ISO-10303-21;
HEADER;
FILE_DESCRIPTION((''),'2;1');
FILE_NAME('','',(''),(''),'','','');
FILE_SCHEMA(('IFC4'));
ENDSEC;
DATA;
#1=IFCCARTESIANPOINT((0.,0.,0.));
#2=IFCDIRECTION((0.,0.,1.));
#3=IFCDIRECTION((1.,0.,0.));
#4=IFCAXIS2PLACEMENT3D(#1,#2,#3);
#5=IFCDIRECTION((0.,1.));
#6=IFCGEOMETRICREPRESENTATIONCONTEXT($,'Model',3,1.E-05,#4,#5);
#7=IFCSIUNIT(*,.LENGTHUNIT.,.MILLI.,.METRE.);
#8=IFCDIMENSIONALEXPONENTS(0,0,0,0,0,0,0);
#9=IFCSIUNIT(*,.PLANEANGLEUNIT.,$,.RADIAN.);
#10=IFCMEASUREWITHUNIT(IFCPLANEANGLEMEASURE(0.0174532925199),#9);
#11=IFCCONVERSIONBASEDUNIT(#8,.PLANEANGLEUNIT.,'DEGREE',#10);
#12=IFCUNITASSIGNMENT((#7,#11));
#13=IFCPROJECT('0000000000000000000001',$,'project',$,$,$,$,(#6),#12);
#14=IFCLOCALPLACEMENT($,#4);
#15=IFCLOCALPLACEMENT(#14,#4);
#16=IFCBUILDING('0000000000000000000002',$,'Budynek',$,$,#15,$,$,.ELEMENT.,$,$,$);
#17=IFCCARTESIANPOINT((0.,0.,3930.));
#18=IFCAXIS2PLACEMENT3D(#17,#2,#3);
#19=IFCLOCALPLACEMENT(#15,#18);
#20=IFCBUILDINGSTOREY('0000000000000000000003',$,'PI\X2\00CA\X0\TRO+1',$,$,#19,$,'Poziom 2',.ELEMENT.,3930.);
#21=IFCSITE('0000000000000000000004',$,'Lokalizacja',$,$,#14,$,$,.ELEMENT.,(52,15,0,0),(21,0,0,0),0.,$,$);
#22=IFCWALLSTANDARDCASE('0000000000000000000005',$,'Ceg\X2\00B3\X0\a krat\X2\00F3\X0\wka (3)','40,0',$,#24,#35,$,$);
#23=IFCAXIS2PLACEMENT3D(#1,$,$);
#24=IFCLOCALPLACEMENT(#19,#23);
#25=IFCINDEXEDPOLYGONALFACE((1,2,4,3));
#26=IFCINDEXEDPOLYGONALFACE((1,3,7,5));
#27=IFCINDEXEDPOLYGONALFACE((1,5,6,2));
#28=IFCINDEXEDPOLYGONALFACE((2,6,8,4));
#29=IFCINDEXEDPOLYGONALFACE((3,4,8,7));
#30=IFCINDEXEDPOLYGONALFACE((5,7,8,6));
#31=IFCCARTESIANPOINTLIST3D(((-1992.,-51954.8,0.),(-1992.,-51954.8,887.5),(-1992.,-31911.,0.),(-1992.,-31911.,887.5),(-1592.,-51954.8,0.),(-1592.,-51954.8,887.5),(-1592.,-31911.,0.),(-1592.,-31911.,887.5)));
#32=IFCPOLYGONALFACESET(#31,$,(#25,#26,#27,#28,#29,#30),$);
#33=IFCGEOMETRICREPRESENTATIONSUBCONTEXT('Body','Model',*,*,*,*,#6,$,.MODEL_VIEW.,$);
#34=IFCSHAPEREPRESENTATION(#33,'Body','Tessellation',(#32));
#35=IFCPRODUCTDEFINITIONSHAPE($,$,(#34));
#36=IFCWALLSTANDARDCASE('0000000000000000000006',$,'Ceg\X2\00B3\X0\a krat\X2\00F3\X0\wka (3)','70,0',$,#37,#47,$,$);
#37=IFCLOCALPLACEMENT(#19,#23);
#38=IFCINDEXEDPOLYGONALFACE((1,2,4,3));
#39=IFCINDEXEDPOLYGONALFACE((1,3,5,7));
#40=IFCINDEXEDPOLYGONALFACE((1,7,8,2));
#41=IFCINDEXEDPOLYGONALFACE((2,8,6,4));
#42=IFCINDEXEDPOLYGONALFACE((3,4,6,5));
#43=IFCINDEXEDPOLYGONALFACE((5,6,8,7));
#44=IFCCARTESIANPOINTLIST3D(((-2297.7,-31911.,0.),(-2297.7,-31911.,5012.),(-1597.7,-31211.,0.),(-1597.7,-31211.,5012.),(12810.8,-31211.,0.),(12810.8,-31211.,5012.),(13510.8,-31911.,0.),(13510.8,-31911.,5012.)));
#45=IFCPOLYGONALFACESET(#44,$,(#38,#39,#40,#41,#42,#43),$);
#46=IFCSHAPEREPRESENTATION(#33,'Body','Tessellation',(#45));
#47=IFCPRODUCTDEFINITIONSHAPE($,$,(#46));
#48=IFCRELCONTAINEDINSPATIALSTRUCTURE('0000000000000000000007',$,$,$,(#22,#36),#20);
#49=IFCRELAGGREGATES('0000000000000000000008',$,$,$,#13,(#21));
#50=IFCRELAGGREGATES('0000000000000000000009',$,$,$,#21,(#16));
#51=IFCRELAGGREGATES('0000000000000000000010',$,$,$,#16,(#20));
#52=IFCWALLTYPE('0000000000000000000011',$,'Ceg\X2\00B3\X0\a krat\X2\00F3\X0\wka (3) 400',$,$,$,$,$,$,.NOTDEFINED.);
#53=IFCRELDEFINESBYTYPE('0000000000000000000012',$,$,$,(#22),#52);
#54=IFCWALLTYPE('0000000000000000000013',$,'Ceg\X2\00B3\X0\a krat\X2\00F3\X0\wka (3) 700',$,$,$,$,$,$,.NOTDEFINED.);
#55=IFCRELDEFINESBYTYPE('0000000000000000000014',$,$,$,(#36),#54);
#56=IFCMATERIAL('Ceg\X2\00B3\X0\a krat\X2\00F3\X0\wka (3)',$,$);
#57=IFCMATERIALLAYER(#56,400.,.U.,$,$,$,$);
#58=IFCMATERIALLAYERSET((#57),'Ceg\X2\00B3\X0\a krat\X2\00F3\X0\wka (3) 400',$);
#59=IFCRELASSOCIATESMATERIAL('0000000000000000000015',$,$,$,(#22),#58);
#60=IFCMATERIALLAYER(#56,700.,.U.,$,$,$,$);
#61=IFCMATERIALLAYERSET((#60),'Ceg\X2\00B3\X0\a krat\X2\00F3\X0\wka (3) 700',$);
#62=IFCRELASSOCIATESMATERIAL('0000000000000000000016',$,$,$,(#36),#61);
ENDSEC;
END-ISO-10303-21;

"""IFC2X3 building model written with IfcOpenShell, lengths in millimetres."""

from ifc_helpers import new_model, entity, si_unit, converted_unit, direction, frame, origin_with_axes, place, context, subcontext, project, spatial, polyline, outline, extrude, material, layer, layer_set, layer_usage, type_object, element, save


model = new_model("IFC2X3")

# Units and contexts
model_context = context("Model", 3, precision=1e-05, world=origin_with_axes(), true_north=direction((0.0, 1.0)))
body_context = subcontext(model_context, "Body", "Model", "MODEL_VIEW")
ifc_project = project(units=[si_unit("LENGTHUNIT", "METRE", prefix="MILLI"), converted_unit("PLANEANGLEUNIT", "DEGREE", entity("IfcPlaneAngleMeasure", 0.0174532925199), si_unit("PLANEANGLEUNIT", "RADIAN"), dimensions=[0, 0, 0, 0, 0, 0, 0])], contexts=[model_context])

# Site, building, storey
site_placement = place(None, origin_with_axes())
site = spatial("IfcSite", under=ifc_project, at=site_placement, Name="Lokalizacja", CompositionType="ELEMENT", RefLatitude=(52, 15, 0, 0), RefLongitude=(21, 0, 0, 0), RefElevation=0.0)
building_placement = place(site_placement, origin_with_axes())
building = spatial("IfcBuilding", under=site, at=building_placement, Name="Budynek", CompositionType="ELEMENT")
storey_placement = place(building_placement, frame((0.0, 0.0, 3930.0), z_axis=(0.0, 0.0, 1.0), x_axis=(1.0, 0.0, 0.0)))
storey = spatial("IfcBuildingStorey", under=building, at=storey_placement, Name="PIÊTRO+1", LongName="Poziom 2", CompositionType="ELEMENT", Elevation=3930.0)

# Walls
ifc_material = material(Name="Ceg³a kratówka (3)")
ifc_layer_1 = layer(ifc_material, 400.0, ventilated="UNKNOWN")
ifc_layer_set_1 = layer_set([ifc_layer_1], Name="Ceg³a kratówka (3) 400")
ifc_layer_usage_1 = layer_usage(ifc_layer_set_1, "AXIS2", "NEGATIVE", 200.0)
wall_type_1 = type_object("IfcWallType", Name="Ceg³a kratówka (3) 400", PredefinedType="NOTDEFINED")
wall_1_placement = place(storey_placement, frame((-1792.0, -31911.0, 0.0), z_axis=(0.0, 0.0, 1.0), x_axis=(0.0, -1.0, 0.0)))
element("IfcWallStandardCase", 1, at=wall_1_placement, inside=storey, type_object=wall_type_1, material=ifc_layer_usage_1, Name="Ceg³a kratówka (3)", Description="40,0", context=body_context, shape_type="SweptSolid", body=[
    extrude(outline(polyline([(0.0, -200.0), (20043.8, -200.0), (20043.8, 200.0), (0.0, 200.0), (0.0, -200.0)])), origin_with_axes(), (0.0, 0.0, 1.0), 887.5),
])
ifc_layer_2 = layer(ifc_material, 700.0, ventilated="UNKNOWN")
ifc_layer_set_2 = layer_set([ifc_layer_2], Name="Ceg³a kratówka (3) 700")
ifc_layer_usage_2 = layer_usage(ifc_layer_set_2, "AXIS2", "NEGATIVE", 0.0)
wall_type_2 = type_object("IfcWallType", Name="Ceg³a kratówka (3) 700", PredefinedType="NOTDEFINED")
wall_2_placement = place(storey_placement, frame((-1597.7, -31211.0, 0.0), z_axis=(0.0, 0.0, 1.0), x_axis=(1.0, 0.0, 0.0)))
element("IfcWallStandardCase", 2, at=wall_2_placement, inside=storey, type_object=wall_type_2, material=ifc_layer_usage_2, Name="Ceg³a kratówka (3)", Description="70,0", context=body_context, shape_type="SweptSolid", body=[
    extrude(outline(polyline([(-700.0, -700.0), (15108.5, -700.0), (14408.5, 0.0), (0.0, 0.0), (-700.0, -700.0)])), origin_with_axes(), (0.0, 0.0, 1.0), 5012.0),
])

save(model, "model.ifc")
